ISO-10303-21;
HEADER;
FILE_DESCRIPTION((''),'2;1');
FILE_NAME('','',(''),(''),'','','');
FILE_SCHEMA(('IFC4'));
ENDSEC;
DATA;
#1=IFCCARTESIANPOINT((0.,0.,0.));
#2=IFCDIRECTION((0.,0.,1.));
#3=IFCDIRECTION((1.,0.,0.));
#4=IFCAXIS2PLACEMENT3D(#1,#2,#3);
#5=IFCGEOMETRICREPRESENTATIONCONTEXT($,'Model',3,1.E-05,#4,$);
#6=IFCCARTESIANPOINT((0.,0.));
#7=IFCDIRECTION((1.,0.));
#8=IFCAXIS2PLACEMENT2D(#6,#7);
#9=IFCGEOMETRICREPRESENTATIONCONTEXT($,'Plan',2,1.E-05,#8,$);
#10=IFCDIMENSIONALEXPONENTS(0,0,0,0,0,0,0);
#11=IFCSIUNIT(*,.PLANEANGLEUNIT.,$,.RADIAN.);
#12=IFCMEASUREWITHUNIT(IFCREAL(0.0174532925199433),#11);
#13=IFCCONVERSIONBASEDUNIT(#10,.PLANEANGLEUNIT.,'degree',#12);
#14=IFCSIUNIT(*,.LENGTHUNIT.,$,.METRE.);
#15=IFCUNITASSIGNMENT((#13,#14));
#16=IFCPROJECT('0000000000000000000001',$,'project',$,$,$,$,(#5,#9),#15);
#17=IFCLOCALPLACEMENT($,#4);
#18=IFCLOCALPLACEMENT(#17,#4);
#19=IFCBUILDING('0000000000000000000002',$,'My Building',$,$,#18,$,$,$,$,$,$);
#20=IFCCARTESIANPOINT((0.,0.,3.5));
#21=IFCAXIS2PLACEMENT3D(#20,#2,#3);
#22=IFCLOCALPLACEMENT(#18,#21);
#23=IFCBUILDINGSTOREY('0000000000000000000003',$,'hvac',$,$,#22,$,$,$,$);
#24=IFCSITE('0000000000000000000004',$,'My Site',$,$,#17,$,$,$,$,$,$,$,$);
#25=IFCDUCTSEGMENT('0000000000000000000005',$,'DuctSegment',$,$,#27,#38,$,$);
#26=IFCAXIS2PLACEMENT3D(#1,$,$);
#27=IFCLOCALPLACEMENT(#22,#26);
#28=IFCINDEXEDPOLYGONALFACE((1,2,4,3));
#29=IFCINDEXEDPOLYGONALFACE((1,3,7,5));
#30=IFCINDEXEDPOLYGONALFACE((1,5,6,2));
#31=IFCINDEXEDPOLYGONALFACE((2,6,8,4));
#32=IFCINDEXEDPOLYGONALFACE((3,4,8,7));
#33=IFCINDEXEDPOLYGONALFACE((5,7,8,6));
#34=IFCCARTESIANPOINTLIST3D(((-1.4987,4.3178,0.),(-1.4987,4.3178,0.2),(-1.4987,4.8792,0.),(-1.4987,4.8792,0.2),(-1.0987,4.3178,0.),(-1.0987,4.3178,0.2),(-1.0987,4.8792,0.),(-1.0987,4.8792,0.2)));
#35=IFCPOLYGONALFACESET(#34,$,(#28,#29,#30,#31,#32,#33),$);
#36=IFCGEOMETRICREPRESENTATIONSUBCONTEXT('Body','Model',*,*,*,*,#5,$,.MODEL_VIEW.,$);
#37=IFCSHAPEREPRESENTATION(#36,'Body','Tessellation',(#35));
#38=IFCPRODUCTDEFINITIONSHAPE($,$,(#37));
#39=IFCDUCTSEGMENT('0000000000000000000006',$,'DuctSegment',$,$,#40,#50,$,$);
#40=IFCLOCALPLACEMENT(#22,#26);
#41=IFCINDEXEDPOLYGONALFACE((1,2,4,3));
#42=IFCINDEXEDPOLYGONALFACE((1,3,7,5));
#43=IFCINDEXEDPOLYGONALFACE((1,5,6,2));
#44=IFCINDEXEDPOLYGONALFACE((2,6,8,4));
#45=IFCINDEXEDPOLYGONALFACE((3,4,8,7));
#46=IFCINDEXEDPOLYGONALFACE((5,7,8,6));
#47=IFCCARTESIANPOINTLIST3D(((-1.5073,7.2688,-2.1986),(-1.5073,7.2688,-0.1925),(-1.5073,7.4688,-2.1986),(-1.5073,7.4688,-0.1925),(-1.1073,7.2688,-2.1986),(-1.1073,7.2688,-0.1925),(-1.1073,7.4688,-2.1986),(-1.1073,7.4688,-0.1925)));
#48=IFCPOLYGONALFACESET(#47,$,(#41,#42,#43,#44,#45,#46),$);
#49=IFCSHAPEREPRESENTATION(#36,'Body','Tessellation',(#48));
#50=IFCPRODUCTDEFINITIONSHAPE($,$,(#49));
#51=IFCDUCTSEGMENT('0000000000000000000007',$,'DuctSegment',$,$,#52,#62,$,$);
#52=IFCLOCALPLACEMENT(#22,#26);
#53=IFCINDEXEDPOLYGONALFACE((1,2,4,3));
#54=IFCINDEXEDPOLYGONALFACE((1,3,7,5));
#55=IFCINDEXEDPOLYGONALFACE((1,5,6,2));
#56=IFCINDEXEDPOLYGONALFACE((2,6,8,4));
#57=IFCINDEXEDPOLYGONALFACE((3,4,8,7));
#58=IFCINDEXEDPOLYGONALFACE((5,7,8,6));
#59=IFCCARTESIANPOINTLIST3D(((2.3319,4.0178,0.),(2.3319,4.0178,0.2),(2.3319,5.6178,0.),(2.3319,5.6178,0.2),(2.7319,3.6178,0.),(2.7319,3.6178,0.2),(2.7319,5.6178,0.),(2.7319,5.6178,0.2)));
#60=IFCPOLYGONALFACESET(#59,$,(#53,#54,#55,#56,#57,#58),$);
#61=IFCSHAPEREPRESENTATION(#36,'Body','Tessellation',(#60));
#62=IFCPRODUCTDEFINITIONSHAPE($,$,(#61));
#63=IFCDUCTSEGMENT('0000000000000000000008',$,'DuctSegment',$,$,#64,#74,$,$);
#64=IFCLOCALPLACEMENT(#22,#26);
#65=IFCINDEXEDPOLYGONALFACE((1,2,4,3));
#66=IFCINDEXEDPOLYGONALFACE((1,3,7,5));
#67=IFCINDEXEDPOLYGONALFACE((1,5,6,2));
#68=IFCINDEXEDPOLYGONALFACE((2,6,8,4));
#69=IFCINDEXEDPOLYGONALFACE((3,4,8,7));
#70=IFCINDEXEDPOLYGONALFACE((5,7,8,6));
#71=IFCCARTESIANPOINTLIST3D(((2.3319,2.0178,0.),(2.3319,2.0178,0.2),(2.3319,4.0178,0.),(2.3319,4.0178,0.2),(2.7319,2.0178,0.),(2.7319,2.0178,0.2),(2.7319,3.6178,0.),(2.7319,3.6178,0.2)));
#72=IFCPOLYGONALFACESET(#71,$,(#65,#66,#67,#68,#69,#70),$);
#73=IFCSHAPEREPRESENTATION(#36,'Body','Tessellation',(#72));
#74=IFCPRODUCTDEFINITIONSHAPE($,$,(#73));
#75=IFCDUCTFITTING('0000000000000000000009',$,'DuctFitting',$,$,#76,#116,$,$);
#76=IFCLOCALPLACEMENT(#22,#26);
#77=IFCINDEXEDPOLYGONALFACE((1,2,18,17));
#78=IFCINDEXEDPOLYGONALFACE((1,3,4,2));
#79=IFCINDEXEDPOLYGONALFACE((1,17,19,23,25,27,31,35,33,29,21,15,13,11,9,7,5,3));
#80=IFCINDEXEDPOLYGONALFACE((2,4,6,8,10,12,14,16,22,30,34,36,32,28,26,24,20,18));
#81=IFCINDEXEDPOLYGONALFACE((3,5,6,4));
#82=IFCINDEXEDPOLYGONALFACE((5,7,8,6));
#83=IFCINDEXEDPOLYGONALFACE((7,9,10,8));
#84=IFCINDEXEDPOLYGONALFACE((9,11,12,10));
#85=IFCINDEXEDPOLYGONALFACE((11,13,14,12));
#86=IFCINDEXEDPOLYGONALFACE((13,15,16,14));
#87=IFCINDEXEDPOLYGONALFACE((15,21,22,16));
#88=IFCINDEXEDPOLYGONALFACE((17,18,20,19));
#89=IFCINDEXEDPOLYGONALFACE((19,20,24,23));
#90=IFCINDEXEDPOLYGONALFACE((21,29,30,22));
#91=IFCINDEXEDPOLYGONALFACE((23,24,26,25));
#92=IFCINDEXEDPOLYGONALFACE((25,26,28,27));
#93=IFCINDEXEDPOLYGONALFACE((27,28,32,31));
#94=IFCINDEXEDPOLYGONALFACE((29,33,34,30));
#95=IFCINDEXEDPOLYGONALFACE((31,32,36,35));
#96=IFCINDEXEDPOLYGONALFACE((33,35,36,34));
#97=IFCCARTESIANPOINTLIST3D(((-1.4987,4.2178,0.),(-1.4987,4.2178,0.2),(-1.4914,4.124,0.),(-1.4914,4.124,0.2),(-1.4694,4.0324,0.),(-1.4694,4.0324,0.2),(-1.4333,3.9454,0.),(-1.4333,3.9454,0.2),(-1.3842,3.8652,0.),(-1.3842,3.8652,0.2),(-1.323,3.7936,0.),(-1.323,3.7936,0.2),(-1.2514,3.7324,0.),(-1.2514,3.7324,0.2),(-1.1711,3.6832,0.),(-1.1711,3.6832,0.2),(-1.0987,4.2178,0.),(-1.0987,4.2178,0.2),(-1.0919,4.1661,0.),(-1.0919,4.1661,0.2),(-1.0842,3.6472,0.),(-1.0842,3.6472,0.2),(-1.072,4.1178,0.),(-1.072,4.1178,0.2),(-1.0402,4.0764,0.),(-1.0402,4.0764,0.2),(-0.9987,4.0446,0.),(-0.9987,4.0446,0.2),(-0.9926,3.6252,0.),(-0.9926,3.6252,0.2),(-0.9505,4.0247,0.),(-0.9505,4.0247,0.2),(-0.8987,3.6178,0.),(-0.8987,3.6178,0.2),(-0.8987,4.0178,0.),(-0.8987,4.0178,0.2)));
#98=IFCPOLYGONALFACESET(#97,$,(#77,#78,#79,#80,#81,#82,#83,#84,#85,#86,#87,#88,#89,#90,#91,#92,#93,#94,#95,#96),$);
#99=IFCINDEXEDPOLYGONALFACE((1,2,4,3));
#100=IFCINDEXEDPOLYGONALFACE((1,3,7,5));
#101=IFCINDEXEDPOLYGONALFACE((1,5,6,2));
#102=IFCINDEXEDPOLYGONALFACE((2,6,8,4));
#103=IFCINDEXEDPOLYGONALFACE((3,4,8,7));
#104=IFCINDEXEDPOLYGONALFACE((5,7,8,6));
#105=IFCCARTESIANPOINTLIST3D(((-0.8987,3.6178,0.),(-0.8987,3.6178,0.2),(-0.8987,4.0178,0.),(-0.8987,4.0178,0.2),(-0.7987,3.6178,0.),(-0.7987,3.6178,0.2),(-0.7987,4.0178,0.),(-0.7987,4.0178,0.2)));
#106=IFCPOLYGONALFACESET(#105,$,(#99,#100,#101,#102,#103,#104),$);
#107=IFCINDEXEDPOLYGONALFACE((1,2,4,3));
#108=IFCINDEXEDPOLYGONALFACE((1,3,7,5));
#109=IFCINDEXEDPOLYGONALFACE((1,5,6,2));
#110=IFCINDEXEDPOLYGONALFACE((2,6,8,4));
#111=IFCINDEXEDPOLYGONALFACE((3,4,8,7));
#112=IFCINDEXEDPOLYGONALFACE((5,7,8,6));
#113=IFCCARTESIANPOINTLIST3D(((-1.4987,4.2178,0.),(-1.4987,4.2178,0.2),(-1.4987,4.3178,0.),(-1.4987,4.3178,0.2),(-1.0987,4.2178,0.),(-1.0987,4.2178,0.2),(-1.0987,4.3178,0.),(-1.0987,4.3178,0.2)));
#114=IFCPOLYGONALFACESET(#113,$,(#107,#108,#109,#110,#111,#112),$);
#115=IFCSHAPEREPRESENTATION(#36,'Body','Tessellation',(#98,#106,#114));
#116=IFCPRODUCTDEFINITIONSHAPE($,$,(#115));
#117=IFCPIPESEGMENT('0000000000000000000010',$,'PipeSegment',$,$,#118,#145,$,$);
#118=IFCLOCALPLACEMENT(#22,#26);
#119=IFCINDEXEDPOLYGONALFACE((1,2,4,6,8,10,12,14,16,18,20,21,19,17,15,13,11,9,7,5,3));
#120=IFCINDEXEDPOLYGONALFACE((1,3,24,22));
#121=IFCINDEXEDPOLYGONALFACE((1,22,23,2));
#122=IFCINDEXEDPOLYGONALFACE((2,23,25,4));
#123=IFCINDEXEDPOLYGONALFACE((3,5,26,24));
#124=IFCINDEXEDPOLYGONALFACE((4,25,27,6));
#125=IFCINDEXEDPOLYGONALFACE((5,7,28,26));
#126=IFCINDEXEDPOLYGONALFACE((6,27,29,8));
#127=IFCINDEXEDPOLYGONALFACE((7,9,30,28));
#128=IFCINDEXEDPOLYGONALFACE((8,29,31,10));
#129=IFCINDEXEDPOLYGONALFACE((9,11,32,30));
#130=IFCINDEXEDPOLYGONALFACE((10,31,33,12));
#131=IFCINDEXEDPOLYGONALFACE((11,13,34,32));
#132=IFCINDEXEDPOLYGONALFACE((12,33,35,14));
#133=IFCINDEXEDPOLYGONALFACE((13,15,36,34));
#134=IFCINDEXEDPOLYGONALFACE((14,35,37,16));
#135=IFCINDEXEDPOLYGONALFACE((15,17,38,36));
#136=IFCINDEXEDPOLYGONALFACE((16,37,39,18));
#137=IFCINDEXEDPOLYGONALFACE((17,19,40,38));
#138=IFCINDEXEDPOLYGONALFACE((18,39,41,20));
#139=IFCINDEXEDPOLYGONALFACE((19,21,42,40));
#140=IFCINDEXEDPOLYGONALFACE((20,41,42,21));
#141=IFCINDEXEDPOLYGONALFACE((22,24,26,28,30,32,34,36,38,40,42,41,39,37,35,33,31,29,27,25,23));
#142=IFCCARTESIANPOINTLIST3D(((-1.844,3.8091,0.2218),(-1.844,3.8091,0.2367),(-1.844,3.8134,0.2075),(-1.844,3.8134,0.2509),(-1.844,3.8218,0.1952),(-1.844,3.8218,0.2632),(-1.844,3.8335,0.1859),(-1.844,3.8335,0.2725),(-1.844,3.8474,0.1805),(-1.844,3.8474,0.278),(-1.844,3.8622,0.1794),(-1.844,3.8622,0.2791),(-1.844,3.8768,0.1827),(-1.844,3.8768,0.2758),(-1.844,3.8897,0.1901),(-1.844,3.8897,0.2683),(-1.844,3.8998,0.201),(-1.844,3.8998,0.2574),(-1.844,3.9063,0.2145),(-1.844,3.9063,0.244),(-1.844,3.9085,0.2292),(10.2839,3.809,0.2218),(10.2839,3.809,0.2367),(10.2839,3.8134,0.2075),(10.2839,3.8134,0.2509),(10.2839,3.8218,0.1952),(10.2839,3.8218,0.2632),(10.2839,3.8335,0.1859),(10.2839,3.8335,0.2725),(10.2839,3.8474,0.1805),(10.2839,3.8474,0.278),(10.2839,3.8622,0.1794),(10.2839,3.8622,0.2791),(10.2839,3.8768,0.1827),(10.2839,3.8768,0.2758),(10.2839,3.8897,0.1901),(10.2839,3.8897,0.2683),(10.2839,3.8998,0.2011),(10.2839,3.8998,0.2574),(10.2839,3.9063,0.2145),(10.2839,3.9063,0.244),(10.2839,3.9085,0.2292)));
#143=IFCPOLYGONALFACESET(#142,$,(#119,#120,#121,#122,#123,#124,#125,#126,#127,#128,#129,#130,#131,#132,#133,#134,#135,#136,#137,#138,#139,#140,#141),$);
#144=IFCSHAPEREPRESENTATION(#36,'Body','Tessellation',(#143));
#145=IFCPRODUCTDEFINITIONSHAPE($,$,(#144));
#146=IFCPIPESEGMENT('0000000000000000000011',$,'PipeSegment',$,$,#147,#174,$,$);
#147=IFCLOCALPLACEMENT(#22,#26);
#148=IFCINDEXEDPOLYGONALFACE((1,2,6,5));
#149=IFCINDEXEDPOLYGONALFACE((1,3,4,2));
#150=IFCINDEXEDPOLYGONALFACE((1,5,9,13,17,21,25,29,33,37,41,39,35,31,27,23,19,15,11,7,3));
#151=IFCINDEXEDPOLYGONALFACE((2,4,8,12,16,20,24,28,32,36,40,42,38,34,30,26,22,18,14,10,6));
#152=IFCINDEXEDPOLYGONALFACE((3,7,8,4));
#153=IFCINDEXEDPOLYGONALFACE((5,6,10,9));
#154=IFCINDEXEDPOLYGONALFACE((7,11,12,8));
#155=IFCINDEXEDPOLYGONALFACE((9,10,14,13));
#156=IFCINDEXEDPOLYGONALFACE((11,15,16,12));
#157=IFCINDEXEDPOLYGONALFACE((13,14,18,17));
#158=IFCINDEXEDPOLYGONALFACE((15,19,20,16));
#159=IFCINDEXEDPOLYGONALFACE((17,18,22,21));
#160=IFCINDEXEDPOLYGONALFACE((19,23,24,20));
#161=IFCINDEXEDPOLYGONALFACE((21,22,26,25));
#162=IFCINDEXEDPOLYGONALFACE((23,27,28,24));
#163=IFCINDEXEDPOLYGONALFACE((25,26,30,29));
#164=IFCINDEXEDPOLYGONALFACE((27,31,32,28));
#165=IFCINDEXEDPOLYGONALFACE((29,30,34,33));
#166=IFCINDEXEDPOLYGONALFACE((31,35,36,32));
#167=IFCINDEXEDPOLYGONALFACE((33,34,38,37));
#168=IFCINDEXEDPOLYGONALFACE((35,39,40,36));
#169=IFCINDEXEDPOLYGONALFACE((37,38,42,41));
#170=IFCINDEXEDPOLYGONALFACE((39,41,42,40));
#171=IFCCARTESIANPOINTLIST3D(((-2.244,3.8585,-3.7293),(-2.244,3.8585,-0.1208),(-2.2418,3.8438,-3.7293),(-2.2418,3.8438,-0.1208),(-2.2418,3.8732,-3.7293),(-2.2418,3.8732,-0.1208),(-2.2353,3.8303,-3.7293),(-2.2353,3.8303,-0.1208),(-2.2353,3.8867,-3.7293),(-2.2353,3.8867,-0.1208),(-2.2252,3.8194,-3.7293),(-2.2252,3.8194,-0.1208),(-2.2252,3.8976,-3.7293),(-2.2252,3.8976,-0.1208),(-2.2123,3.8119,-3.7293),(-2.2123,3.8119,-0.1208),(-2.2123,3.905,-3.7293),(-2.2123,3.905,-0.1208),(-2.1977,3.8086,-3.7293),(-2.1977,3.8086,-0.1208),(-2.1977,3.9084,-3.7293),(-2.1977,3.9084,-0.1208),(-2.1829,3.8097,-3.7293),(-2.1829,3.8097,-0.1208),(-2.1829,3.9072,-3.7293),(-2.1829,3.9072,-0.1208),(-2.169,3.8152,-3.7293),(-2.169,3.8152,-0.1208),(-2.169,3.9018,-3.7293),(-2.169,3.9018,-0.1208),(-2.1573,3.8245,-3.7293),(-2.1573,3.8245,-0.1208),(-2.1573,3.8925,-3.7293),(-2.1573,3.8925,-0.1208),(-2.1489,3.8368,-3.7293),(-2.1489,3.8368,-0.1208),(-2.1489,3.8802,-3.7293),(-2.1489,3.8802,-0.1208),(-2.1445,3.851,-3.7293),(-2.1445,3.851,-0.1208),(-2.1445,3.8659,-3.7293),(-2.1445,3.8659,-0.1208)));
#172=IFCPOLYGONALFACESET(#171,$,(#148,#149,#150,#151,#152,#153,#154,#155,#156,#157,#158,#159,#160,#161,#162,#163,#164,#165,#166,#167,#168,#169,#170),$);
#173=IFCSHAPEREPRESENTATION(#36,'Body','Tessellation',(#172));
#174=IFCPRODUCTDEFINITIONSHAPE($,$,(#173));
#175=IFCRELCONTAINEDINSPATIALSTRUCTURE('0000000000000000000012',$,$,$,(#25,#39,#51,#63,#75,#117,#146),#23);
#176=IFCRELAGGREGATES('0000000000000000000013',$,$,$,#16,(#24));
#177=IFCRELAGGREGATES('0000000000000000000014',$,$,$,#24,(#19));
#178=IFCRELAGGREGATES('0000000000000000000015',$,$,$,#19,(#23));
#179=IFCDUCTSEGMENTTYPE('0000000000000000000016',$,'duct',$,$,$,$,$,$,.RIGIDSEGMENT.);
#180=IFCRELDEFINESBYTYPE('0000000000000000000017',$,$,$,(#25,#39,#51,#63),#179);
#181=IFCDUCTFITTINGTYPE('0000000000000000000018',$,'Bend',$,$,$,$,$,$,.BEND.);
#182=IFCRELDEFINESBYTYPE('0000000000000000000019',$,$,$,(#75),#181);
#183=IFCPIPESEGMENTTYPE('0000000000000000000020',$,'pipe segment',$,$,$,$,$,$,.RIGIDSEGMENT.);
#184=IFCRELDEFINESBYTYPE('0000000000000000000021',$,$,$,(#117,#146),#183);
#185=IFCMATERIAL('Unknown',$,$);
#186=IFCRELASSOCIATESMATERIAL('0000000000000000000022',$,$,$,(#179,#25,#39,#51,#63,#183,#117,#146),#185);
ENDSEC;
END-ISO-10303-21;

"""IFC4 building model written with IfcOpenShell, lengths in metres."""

from ifc_helpers import new_model, entity, si_unit, converted_unit, frame, origin_with_axes, origin_2d_with_axis, place, context, subcontext, project, spatial, line, arc, indexed_curve, rectangle, circle, outline, extrude, clip, halfspace, source, transform, mapped, material, material_profile, profile_set, profile_usage, type_object, type_shapes, element, save


model = new_model("IFC4")

# Units and contexts
model_context = context("Model", 3, precision=1e-05, world=origin_with_axes())
plan_context = context("Plan", 2, precision=1e-05, world=origin_2d_with_axis())
body_context_1 = subcontext(model_context, "Body", "Model", "MODEL_VIEW")
ifc_project = project(units=[converted_unit("PLANEANGLEUNIT", "degree", entity("IfcReal", 0.0174532925199433), si_unit("PLANEANGLEUNIT", "RADIAN"), dimensions=[0, 0, 0, 0, 0, 0, 0]), si_unit("LENGTHUNIT", "METRE")], contexts=[model_context, plan_context])

# Site, building, storey
site_placement = place(None, origin_with_axes())
site = spatial("IfcSite", under=ifc_project, at=site_placement, Name="My Site")
building_placement = place(site_placement, origin_with_axes())
building = spatial("IfcBuilding", under=site, at=building_placement, Name="My Building")
storey_placement = place(building_placement, frame((0.0, 0.0, 3.5), z_axis=(0.0, 0.0, 1.0), x_axis=(1.0, 0.0, 0.0)))
storey = spatial("IfcBuildingStorey", under=building, at=storey_placement, Name="hvac")

# Shared definitions
ifc_material = material(Name="Unknown")

# Duct segments
ifc_material_profile_1 = material_profile(ifc_material, rectangle(XDim=0.4, YDim=0.2))
ifc_profile_set_1 = profile_set([ifc_material_profile_1])
duct_segment_type = type_object("IfcDuctSegmentType", Name="duct", PredefinedType="RIGIDSEGMENT", material=ifc_profile_set_1)
ifc_profile_usage_1 = profile_usage(ifc_profile_set_1, cardinal=5)
duct_segment_1_placement = place(storey_placement, frame((-1.2987, 4.3178, 0.1), z_axis=(0.0, 1.0, 0.0), x_axis=(-1.0, 0.0, 0.0)))
element("IfcDuctSegment", 1, at=duct_segment_1_placement, inside=storey, type_object=duct_segment_type, material=ifc_profile_usage_1, Name="DuctSegment", context=body_context_1, shape_type="SweptSolid", body=[
    extrude(rectangle(XDim=0.4, YDim=0.2), origin_with_axes(), (0.0, 0.0, 1.0), 0.5614),
])
ifc_profile_usage_2 = profile_usage(ifc_profile_set_1, cardinal=5)
duct_segment_2_placement = place(storey_placement, frame((-1.3073, 7.3688, -0.1925), z_axis=(0.0, 0.0, -1.0), x_axis=(-1.0, 0.0, 0.0)))
element("IfcDuctSegment", 2, at=duct_segment_2_placement, inside=storey, type_object=duct_segment_type, material=ifc_profile_usage_2, Name="DuctSegment", context=body_context_1, shape_type="SweptSolid", body=[
    extrude(rectangle(XDim=0.4, YDim=0.2), origin_with_axes(), (0.0, 0.0, 1.0), 2.0062),
])
ifc_profile_usage_3 = profile_usage(ifc_profile_set_1, cardinal=5)
duct_segment_3_placement = place(storey_placement, frame((2.5319, 3.6178, 0.1), z_axis=(0.0, 1.0, 0.0), x_axis=(-1.0, 0.0, 0.0)))
element("IfcDuctSegment", 3, at=duct_segment_3_placement, inside=storey, type_object=duct_segment_type, material=ifc_profile_usage_3, Name="DuctSegment", context=body_context_1, shape_type="Clipping", body=[
    clip(extrude(rectangle(XDim=0.4, YDim=0.2), origin_with_axes(), (0.0, 0.0, 1.0), 2.0), halfspace(frame((-0.2, 0.0, 0.0), z_axis=(0.707107, 0.0, -0.707107), x_axis=(0.0, -1.0, 0.0)), False)),
])
ifc_profile_usage_4 = profile_usage(ifc_profile_set_1, cardinal=5)
duct_segment_4_placement = place(storey_placement, frame((2.5319, 4.0178, 0.1), z_axis=(0.0, -1.0, 0.0), x_axis=(1.0, 0.0, 0.0)))
element("IfcDuctSegment", 4, at=duct_segment_4_placement, inside=storey, type_object=duct_segment_type, material=ifc_profile_usage_4, Name="DuctSegment", context=body_context_1, shape_type="Clipping", body=[
    clip(extrude(rectangle(XDim=0.4, YDim=0.2), origin_with_axes(), (0.0, 0.0, 1.0), 2.0), halfspace(frame((-0.2, 0.0, 0.0), z_axis=(0.707107, 0.0, -0.707107), x_axis=(0.0, -1.0, 0.0)), False)),
])

# Duct fitting
duct_fitting_type = type_object("IfcDuctFittingType", Name="Bend", PredefinedType="BEND")
shared_shape_1 = source(origin_with_axes(), body_context_1, "Body", "SweptSolid", [
    extrude(outline(indexed_curve([(-0.2, 0.0), (-0.2586, -0.1414), (-0.4, -0.2), (-0.4, -0.6), (0.0243, -0.4243), (0.2, 0.0)], segments=[arc(1, 2, 3), line(3, 4), arc(4, 5, 6), line(6, 1)])), frame((0.0, -0.1, -0.1), z_axis=(0.0, -1.0, 0.0), x_axis=(1.0, 0.0, 0.0)), (0.0, 0.0, -1.0), 0.2),
    extrude(rectangle(XDim=0.4, YDim=0.2), origin_with_axes(), (0.0, 0.0, -1.0), 0.1),
    extrude(rectangle(XDim=0.4, YDim=0.2), frame((-0.4, 0.0, -0.5), z_axis=(-1.0, 0.0, 0.0), x_axis=(0.0, 0.0, -1.0)), (0.0, 0.0, 1.0), 0.1),
])
type_shapes(duct_fitting_type, [shared_shape_1])
duct_fitting_placement = place(storey_placement, frame((-0.7987, 3.8178, 0.1), z_axis=(1.0, 0.0, 0.0), x_axis=(0.0, -1.0, 0.0)))
element("IfcDuctFitting", 5, at=duct_fitting_placement, inside=storey, type_object=duct_fitting_type, Name="DuctFitting", context=body_context_1, shape_type="MappedRepresentation", body=[
    mapped(shared_shape_1, transform((0.0, 0.0, 0.0), x_axis=(1.0, 0.0, 0.0), y_axis=(0.0, 1.0, 0.0), z_axis=(0.0, 0.0, 1.0), scale=1.0)),
])

# Pipe segments
ifc_material_profile_2 = material_profile(ifc_material, circle(Radius=0.05))
ifc_profile_set_2 = profile_set([ifc_material_profile_2])
ifc_profile_usage_5 = profile_usage(ifc_profile_set_2, cardinal=5)
pipe_segment_type = type_object("IfcPipeSegmentType", Name="pipe segment", PredefinedType="RIGIDSEGMENT", material=ifc_profile_set_2)
pipe_segment_1_placement = place(storey_placement, frame((-1.844, 3.8585, 0.2292), z_axis=(1.0, 0.0, 0.0), x_axis=(0.0, 1.0, 0.0)))
element("IfcPipeSegment", 6, at=pipe_segment_1_placement, inside=storey, type_object=pipe_segment_type, material=ifc_profile_usage_5, Name="PipeSegment", context=body_context_1, shape_type="SweptSolid", body=[
    extrude(circle(Radius=0.05), origin_with_axes(), (0.0, 0.0, 1.0), 12.1279),
])
ifc_profile_usage_6 = profile_usage(ifc_profile_set_2, cardinal=5)
pipe_segment_2_placement = place(storey_placement, frame((-2.194, 3.8585, -0.1208), z_axis=(0.0, 0.0, -1.0), x_axis=(-1.0, 0.0, 0.0)))
element("IfcPipeSegment", 7, at=pipe_segment_2_placement, inside=storey, type_object=pipe_segment_type, material=ifc_profile_usage_6, Name="PipeSegment", context=body_context_1, shape_type="SweptSolid", body=[
    extrude(circle(Radius=0.05), origin_with_axes(), (0.0, 0.0, 1.0), 3.6085),
])

save(model, "model.ifc")
